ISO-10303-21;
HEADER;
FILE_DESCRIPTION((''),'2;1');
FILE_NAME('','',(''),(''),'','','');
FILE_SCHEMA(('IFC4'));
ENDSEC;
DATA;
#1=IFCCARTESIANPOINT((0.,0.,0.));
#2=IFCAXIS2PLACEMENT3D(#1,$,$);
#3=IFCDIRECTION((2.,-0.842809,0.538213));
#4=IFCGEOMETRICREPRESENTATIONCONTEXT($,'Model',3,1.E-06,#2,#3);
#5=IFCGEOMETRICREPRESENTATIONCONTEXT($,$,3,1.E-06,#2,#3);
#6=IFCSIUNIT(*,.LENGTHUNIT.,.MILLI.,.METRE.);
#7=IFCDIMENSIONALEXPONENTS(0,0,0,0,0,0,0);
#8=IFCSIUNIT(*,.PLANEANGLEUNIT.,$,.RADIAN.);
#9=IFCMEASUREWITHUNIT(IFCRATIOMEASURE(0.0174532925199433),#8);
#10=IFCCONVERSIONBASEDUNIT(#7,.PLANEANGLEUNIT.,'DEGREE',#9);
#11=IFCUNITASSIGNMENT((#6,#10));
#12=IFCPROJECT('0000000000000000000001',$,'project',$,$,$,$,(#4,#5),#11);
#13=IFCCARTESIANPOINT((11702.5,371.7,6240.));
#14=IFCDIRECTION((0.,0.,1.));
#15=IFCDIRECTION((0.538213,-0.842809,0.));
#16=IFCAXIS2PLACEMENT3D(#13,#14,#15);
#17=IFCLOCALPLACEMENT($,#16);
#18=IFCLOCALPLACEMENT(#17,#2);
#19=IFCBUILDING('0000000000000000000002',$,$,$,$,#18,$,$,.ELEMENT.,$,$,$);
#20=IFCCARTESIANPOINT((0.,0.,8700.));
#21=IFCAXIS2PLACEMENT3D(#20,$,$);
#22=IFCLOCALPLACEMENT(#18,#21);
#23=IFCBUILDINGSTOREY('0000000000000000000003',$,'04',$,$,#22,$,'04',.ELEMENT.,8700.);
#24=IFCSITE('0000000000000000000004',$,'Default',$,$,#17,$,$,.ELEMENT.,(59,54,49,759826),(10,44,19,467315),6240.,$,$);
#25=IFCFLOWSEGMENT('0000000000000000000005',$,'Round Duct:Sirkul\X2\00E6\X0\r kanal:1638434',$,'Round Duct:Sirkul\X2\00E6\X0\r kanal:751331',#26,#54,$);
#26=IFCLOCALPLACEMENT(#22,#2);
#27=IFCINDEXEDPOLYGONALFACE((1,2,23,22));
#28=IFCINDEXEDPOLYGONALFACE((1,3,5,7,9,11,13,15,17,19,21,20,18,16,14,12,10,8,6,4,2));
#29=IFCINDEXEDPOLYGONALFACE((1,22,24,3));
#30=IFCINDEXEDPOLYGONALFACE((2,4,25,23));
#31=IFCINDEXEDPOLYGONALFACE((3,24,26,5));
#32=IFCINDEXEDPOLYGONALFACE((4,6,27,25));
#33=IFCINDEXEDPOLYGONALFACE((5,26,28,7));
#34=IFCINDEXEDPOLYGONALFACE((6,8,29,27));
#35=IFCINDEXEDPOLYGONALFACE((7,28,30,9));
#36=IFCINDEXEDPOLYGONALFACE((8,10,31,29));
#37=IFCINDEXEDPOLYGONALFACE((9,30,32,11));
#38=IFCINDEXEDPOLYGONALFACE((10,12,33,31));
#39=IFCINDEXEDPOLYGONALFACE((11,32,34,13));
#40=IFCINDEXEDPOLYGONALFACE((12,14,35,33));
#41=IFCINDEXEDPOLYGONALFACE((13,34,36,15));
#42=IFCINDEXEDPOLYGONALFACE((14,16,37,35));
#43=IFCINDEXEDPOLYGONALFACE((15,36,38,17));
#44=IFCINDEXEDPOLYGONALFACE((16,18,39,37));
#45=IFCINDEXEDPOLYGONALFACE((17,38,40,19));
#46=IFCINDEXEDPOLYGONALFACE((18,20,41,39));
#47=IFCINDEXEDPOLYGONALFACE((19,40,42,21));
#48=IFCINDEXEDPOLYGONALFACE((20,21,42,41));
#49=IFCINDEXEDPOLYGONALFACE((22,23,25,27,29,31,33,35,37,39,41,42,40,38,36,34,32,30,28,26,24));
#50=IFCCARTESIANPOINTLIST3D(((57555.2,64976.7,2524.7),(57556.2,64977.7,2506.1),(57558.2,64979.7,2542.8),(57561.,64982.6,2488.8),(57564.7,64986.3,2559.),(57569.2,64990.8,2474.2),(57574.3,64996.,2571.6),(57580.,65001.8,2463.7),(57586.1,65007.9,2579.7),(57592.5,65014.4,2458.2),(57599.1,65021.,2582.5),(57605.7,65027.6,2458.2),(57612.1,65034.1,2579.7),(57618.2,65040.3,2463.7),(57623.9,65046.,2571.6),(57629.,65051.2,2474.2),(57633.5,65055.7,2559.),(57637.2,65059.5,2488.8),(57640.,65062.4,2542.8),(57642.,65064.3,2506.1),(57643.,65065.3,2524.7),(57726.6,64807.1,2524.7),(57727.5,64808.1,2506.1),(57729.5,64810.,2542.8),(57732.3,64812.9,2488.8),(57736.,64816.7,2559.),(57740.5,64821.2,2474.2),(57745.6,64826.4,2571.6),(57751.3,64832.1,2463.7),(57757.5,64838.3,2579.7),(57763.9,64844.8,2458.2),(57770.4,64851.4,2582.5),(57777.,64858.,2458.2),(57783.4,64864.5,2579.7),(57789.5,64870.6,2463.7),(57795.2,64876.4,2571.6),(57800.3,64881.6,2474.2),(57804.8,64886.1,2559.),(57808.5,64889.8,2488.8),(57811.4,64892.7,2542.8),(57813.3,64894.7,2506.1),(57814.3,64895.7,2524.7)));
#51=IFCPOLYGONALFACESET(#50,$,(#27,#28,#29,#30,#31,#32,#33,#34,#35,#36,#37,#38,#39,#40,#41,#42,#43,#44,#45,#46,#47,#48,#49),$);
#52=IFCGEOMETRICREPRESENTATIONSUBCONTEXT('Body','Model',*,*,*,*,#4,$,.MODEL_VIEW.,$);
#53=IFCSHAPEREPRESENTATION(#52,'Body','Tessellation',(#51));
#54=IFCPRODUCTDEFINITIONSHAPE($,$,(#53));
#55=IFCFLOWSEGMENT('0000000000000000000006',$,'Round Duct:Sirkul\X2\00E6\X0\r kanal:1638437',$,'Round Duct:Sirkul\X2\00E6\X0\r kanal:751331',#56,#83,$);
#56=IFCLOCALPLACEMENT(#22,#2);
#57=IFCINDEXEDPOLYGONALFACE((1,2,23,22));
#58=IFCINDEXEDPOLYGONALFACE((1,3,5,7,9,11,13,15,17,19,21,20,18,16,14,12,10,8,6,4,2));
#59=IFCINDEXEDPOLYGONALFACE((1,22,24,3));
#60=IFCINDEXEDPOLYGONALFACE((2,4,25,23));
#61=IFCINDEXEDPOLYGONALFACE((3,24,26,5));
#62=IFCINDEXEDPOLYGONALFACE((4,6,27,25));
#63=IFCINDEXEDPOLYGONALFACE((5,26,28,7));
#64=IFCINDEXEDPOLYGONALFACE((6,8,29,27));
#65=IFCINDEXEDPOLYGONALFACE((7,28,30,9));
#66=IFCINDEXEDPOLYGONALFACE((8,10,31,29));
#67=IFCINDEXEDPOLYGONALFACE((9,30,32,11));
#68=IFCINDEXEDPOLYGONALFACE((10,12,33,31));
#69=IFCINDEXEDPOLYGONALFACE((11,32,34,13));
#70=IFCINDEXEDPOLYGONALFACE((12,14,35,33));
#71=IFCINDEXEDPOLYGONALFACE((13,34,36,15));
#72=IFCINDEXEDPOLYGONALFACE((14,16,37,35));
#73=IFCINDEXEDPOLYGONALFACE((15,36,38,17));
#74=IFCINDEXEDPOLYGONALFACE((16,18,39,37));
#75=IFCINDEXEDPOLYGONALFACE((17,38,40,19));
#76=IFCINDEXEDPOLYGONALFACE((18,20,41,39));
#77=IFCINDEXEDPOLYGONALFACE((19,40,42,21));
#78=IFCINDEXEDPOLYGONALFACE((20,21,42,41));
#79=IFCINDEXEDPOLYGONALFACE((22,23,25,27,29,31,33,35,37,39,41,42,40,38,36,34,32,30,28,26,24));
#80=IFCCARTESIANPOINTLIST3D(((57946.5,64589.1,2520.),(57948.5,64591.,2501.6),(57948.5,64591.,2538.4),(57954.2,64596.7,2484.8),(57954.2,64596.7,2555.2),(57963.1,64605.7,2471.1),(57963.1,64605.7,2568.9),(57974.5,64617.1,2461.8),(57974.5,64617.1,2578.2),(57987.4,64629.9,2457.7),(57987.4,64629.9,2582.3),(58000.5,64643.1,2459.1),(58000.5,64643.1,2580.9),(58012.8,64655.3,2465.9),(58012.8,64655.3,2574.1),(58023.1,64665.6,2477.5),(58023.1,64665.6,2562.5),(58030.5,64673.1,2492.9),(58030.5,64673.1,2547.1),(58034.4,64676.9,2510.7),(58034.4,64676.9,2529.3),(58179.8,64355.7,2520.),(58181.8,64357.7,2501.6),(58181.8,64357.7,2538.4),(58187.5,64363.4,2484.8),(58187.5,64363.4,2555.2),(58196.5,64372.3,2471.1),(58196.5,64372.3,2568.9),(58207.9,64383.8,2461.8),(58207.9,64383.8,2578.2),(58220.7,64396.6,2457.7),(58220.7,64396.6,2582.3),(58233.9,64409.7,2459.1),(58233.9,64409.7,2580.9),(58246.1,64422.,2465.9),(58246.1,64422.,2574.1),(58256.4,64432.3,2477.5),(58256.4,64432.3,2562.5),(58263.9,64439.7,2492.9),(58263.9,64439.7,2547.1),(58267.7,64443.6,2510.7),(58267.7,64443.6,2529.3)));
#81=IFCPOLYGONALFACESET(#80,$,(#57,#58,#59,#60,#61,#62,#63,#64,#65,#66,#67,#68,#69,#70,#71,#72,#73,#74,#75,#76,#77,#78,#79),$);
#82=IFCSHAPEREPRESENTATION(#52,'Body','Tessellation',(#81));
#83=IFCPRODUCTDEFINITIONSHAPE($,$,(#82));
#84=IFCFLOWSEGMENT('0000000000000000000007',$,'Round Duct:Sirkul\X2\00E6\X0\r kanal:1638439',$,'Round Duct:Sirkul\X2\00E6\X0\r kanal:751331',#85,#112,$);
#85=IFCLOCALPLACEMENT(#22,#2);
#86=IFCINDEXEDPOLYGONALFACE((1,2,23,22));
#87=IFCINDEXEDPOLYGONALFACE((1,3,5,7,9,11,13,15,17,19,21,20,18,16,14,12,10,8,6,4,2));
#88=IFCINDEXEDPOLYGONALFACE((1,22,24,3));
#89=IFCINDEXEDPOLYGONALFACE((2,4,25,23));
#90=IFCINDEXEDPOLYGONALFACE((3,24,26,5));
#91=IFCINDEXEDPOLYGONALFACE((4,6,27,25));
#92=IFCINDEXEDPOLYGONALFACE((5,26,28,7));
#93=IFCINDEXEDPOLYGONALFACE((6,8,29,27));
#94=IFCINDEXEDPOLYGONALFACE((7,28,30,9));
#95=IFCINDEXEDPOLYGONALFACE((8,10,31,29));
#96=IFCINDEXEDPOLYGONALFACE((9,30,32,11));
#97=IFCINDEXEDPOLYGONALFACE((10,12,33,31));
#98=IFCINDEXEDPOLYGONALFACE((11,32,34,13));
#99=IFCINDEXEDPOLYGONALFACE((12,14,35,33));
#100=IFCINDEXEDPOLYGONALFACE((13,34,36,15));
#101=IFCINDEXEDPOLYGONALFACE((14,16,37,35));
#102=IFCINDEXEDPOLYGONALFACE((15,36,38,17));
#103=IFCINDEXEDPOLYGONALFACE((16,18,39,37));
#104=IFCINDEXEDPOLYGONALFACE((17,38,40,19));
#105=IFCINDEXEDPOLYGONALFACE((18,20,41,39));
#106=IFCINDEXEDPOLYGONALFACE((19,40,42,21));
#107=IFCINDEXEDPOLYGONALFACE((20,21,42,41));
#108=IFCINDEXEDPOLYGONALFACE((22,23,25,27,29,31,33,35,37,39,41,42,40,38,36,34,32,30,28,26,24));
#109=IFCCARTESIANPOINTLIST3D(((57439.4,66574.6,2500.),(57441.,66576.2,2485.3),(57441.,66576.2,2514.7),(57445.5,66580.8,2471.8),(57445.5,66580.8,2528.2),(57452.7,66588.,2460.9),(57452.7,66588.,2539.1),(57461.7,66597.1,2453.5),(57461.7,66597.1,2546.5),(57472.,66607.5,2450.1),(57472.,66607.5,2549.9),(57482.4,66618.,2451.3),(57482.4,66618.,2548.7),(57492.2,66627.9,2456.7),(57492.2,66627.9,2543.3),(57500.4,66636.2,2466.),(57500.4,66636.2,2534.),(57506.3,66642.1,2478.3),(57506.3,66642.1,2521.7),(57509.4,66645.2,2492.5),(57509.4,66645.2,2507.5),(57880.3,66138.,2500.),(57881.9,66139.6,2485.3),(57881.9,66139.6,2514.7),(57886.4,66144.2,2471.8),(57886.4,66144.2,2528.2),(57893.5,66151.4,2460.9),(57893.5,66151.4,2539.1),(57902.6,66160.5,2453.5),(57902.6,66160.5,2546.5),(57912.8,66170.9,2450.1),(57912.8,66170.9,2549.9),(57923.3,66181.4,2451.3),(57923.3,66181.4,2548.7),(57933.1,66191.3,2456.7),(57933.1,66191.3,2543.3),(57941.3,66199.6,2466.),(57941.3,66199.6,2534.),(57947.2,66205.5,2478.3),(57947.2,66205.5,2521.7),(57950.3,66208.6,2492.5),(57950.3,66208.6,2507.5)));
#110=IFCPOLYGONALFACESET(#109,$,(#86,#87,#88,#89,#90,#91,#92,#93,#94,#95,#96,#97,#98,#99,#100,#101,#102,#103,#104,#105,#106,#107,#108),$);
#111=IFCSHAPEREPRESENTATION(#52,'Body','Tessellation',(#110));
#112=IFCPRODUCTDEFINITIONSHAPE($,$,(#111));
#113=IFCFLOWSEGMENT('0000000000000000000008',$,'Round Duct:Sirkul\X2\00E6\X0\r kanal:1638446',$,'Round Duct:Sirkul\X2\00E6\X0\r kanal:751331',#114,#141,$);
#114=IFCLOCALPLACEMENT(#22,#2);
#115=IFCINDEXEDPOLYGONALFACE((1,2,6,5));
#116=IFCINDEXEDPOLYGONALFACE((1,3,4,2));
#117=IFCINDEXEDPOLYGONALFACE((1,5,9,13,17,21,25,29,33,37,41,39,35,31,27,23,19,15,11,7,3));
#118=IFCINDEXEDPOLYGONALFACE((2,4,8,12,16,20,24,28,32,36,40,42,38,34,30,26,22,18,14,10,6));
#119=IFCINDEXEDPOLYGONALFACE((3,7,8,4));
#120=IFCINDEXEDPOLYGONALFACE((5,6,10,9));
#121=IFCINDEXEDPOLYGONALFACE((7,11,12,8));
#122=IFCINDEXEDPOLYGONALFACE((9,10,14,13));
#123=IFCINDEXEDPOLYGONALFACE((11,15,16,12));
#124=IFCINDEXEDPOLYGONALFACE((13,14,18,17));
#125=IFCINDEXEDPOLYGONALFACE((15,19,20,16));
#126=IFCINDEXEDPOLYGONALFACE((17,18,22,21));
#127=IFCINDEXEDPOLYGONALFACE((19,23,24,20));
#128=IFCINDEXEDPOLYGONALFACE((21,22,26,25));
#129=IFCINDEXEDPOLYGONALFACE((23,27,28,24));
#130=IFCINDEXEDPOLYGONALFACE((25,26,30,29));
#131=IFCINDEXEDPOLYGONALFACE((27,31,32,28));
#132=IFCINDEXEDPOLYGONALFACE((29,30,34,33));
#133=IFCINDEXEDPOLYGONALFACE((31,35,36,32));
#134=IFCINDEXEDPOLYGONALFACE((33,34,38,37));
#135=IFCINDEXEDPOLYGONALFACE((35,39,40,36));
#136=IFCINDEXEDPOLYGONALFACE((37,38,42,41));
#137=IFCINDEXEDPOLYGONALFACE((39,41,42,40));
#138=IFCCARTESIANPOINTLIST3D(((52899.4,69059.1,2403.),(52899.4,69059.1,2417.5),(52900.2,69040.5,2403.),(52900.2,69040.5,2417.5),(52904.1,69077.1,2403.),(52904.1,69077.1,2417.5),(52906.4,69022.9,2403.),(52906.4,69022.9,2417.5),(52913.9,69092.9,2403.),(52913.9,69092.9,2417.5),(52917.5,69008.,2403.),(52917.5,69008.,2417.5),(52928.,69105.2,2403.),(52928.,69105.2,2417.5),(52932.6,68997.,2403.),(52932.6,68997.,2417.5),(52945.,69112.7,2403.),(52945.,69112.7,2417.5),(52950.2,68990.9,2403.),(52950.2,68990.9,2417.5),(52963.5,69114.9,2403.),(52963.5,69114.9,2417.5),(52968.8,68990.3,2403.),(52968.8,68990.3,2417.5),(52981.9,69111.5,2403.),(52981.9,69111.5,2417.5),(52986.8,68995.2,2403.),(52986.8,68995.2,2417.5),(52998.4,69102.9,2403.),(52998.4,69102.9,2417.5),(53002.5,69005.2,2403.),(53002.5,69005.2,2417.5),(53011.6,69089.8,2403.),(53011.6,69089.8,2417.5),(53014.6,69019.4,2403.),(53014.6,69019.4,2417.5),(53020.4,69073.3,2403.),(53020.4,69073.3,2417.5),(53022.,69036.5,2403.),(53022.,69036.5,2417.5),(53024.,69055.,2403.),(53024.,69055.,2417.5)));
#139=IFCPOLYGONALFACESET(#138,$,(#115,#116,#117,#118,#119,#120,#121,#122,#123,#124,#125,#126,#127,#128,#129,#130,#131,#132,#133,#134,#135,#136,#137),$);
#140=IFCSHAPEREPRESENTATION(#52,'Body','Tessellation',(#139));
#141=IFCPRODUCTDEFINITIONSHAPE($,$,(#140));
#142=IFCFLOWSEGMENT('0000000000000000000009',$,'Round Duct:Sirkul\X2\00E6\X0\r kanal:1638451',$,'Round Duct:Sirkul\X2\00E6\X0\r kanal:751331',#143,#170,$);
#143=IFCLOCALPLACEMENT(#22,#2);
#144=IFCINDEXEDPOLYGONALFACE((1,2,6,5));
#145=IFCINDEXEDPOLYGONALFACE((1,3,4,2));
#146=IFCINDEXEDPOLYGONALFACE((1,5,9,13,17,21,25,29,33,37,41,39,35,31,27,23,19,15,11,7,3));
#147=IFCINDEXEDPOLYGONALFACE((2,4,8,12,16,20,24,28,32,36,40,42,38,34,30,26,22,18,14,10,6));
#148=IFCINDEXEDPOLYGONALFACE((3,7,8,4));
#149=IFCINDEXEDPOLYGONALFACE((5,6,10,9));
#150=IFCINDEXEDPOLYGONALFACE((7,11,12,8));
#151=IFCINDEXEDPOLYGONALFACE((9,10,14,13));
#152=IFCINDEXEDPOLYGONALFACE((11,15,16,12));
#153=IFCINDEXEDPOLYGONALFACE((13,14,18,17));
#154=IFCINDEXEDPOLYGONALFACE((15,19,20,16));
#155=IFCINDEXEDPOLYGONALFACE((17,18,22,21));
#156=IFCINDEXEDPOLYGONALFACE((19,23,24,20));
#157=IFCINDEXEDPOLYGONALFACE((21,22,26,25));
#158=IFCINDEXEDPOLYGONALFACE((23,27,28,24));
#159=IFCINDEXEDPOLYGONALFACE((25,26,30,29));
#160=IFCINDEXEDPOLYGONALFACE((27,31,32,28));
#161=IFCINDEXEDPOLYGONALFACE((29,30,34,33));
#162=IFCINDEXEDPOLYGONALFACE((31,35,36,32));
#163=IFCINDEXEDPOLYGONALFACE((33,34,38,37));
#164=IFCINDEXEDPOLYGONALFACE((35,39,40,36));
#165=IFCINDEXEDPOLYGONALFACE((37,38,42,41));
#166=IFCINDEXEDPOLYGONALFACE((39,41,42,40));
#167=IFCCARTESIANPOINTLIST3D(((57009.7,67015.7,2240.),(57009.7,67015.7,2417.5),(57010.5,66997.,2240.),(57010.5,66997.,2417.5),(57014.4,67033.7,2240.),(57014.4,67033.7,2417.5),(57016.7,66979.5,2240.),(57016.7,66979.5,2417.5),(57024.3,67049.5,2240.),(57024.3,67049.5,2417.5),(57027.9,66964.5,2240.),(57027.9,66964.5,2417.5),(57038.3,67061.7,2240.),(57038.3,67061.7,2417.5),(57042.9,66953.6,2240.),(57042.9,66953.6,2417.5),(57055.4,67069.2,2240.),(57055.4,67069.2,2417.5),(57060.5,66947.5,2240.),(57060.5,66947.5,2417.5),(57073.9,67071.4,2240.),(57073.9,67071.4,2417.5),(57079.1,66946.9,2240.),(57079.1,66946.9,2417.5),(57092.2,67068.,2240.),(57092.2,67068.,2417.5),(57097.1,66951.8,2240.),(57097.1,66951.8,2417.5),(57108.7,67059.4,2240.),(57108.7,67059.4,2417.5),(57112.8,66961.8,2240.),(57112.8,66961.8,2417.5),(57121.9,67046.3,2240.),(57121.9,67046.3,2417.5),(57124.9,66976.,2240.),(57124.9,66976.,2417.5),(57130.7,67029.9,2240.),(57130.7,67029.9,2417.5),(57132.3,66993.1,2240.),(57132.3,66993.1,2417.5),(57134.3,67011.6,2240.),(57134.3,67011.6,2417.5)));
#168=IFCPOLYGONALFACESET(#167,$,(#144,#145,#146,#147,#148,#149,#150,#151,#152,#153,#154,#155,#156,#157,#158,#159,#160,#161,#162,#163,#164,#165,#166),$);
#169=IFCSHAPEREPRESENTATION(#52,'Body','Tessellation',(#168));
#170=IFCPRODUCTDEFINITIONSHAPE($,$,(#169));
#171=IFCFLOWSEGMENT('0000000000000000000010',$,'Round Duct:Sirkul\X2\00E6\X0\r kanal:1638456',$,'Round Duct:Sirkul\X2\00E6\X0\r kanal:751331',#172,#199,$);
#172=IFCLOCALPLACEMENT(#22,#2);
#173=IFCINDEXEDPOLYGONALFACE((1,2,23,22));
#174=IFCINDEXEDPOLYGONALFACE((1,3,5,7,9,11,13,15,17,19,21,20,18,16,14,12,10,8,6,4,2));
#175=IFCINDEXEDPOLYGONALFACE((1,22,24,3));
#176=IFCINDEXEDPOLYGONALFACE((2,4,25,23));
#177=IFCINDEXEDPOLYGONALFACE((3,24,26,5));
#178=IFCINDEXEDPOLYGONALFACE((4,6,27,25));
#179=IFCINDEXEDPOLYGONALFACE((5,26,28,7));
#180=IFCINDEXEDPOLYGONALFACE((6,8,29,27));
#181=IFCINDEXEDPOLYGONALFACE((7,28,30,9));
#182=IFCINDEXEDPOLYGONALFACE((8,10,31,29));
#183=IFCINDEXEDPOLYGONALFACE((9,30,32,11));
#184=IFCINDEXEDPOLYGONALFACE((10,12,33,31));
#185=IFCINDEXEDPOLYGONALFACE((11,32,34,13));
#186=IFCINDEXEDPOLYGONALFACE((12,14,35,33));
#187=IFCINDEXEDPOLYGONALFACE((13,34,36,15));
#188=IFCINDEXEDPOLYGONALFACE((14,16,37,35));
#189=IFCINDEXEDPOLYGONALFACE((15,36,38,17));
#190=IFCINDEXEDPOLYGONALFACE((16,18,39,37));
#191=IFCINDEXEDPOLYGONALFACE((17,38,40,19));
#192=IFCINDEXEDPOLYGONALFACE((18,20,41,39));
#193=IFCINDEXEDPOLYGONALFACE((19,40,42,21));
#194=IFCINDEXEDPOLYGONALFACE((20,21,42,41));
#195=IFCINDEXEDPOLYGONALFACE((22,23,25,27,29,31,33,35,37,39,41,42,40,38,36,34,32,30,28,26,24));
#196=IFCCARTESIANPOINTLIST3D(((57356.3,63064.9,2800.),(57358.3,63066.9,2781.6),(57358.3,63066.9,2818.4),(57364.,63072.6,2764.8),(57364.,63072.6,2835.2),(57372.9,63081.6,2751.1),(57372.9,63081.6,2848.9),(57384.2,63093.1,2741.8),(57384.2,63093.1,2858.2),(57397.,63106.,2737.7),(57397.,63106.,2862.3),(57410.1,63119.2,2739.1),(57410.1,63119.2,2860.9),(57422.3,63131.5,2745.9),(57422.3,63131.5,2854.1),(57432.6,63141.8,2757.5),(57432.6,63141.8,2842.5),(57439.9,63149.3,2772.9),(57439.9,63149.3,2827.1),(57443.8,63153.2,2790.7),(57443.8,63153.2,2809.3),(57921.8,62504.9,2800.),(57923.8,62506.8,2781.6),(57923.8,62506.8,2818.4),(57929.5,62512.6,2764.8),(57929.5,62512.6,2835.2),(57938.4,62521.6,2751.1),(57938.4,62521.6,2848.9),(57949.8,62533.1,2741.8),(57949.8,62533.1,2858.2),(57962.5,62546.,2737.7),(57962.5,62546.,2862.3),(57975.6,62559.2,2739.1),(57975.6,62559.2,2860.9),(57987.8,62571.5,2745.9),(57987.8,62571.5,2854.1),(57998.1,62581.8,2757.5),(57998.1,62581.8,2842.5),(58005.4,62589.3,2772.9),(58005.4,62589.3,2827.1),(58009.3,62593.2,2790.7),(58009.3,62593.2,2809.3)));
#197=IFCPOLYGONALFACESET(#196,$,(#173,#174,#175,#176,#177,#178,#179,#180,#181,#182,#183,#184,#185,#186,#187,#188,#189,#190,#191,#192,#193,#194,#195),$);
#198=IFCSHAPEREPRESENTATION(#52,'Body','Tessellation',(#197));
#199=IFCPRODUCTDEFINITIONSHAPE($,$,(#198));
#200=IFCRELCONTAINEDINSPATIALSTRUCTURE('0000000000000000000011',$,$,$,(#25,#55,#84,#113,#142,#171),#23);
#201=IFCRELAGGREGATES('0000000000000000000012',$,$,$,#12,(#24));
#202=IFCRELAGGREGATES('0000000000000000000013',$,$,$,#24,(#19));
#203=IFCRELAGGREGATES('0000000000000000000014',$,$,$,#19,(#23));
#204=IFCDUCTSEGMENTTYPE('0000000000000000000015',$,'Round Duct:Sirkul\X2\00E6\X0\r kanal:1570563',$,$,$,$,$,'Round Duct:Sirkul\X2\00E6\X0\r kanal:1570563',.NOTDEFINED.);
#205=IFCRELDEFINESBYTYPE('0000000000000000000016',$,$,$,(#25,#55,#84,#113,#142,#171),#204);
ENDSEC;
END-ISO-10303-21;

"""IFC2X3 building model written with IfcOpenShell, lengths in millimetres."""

from ifc_helpers import new_model, entity, si_unit, converted_unit, direction, frame, frame_2d, origin, origin_2d_with_axis, place, context, subcontext, project, spatial, circle, extrude, type_object, element, save


model = new_model("IFC2X3")

# Units and contexts
model_context = context("Model", 3, precision=1e-06, world=origin(), true_north=direction((2.0, -0.842809, 0.538213)))
context_of_model = context(None, 3, precision=1e-06, world=origin(), true_north=direction((2.0, -0.842809, 0.538213)))
body_context = subcontext(model_context, "Body", "Model", "MODEL_VIEW")
ifc_project = project(units=[si_unit("LENGTHUNIT", "METRE", prefix="MILLI"), converted_unit("PLANEANGLEUNIT", "DEGREE", entity("IfcRatioMeasure", 0.0174532925199433), si_unit("PLANEANGLEUNIT", "RADIAN"), dimensions=[0, 0, 0, 0, 0, 0, 0])], contexts=[model_context, context_of_model])

# Site, building, storey
site_placement = place(None, frame((11702.5, 371.7, 6240.0), z_axis=(0.0, 0.0, 1.0), x_axis=(0.538213, -0.842809, 0.0)))
site = spatial("IfcSite", under=ifc_project, at=site_placement, Name="Default", CompositionType="ELEMENT", RefLatitude=(59, 54, 49, 759826), RefLongitude=(10, 44, 19, 467315), RefElevation=6240.0)
building_placement = place(site_placement, origin())
building = spatial("IfcBuilding", under=site, at=building_placement, CompositionType="ELEMENT")
storey_placement = place(building_placement, frame((0.0, 0.0, 8700.0)))
storey = spatial("IfcBuildingStorey", under=building, at=storey_placement, Name="04", LongName="04", CompositionType="ELEMENT", Elevation=8700.0)

# Flow segments
duct_segment_type = type_object("IfcDuctSegmentType", Name="Round Duct:Sirkulær kanal:1570563", ElementType="Round Duct:Sirkulær kanal:1570563", PredefinedType="NOTDEFINED")
flow_segment_1_placement = place(storey_placement, origin())
element("IfcFlowSegment", 1, at=flow_segment_1_placement, inside=storey, type_object=duct_segment_type, Name="Round Duct:Sirkulær kanal:1638434", ObjectType="Round Duct:Sirkulær kanal:751331", context=body_context, shape_type="SweptSolid", body=[
    extrude(circle(Radius=62.5, at=frame_2d((0.0, 0.0), x_axis=(1.0, 0.0))), frame((57599.1, 65021.0, 2520.0), z_axis=(0.710554, -0.703643, 0.0), x_axis=(0.0, 0.0, 1.0)), (0.0, 0.0, 1.0), 241.1),
])
flow_segment_2_placement = place(storey_placement, origin())
element("IfcFlowSegment", 2, at=flow_segment_2_placement, inside=storey, type_object=duct_segment_type, Name="Round Duct:Sirkulær kanal:1638437", ObjectType="Round Duct:Sirkulær kanal:751331", context=body_context, shape_type="SweptSolid", body=[
    extrude(circle(Radius=62.5, at=origin_2d_with_axis()), frame((57990.7, 64633.2, 2520.0), z_axis=(0.707107, -0.707107, 0.0), x_axis=(-0.707107, -0.707107, 0.0)), (0.0, 0.0, 1.0), 330.0),
])
flow_segment_3_placement = place(storey_placement, origin())
element("IfcFlowSegment", 3, at=flow_segment_3_placement, inside=storey, type_object=duct_segment_type, Name="Round Duct:Sirkulær kanal:1638439", ObjectType="Round Duct:Sirkulær kanal:751331", context=body_context, shape_type="SweptSolid", body=[
    extrude(circle(Radius=50.0, at=origin_2d_with_axis()), frame((57915.5, 66173.5, 2500.0), z_axis=(-0.710554, 0.703643, 0.0), x_axis=(-0.703643, -0.710554, 0.0)), (0.0, 0.0, 1.0), 620.5),
])
flow_segment_4_placement = place(storey_placement, origin())
element("IfcFlowSegment", 4, at=flow_segment_4_placement, inside=storey, type_object=duct_segment_type, Name="Round Duct:Sirkulær kanal:1638446", ObjectType="Round Duct:Sirkulær kanal:751331", context=body_context, shape_type="SweptSolid", body=[
    extrude(circle(Radius=62.5, at=frame_2d((0.0, 0.0), x_axis=(1.0, 0.0))), frame((52961.5, 69052.4, 2403.0), z_axis=(0.0, 0.0, 1.0), x_axis=(-0.703643, -0.710554, 0.0)), (0.0, 0.0, 1.0), 14.5),
])
flow_segment_5_placement = place(storey_placement, origin())
element("IfcFlowSegment", 5, at=flow_segment_5_placement, inside=storey, type_object=duct_segment_type, Name="Round Duct:Sirkulær kanal:1638451", ObjectType="Round Duct:Sirkulær kanal:751331", context=body_context, shape_type="SweptSolid", body=[
    extrude(circle(Radius=62.5, at=frame_2d((0.0, 0.0), x_axis=(1.0, 0.0))), frame((57071.8, 67009.0, 2240.0), z_axis=(0.0, 0.0, 1.0), x_axis=(-0.703643, -0.710554, 0.0)), (0.0, 0.0, 1.0), 177.5),
])
flow_segment_6_placement = place(storey_placement, origin())
element("IfcFlowSegment", 6, at=flow_segment_6_placement, inside=storey, type_object=duct_segment_type, Name="Round Duct:Sirkulær kanal:1638456", ObjectType="Round Duct:Sirkulær kanal:751331", context=body_context, shape_type="SweptSolid", body=[
    extrude(circle(Radius=62.5, at=origin_2d_with_axis()), frame((57965.8, 62549.3, 2800.0), z_axis=(-0.710554, 0.703643, 0.0), x_axis=(-0.703643, -0.710554, 0.0)), (0.0, 0.0, 1.0), 795.9),
])

save(model, "model.ifc")
